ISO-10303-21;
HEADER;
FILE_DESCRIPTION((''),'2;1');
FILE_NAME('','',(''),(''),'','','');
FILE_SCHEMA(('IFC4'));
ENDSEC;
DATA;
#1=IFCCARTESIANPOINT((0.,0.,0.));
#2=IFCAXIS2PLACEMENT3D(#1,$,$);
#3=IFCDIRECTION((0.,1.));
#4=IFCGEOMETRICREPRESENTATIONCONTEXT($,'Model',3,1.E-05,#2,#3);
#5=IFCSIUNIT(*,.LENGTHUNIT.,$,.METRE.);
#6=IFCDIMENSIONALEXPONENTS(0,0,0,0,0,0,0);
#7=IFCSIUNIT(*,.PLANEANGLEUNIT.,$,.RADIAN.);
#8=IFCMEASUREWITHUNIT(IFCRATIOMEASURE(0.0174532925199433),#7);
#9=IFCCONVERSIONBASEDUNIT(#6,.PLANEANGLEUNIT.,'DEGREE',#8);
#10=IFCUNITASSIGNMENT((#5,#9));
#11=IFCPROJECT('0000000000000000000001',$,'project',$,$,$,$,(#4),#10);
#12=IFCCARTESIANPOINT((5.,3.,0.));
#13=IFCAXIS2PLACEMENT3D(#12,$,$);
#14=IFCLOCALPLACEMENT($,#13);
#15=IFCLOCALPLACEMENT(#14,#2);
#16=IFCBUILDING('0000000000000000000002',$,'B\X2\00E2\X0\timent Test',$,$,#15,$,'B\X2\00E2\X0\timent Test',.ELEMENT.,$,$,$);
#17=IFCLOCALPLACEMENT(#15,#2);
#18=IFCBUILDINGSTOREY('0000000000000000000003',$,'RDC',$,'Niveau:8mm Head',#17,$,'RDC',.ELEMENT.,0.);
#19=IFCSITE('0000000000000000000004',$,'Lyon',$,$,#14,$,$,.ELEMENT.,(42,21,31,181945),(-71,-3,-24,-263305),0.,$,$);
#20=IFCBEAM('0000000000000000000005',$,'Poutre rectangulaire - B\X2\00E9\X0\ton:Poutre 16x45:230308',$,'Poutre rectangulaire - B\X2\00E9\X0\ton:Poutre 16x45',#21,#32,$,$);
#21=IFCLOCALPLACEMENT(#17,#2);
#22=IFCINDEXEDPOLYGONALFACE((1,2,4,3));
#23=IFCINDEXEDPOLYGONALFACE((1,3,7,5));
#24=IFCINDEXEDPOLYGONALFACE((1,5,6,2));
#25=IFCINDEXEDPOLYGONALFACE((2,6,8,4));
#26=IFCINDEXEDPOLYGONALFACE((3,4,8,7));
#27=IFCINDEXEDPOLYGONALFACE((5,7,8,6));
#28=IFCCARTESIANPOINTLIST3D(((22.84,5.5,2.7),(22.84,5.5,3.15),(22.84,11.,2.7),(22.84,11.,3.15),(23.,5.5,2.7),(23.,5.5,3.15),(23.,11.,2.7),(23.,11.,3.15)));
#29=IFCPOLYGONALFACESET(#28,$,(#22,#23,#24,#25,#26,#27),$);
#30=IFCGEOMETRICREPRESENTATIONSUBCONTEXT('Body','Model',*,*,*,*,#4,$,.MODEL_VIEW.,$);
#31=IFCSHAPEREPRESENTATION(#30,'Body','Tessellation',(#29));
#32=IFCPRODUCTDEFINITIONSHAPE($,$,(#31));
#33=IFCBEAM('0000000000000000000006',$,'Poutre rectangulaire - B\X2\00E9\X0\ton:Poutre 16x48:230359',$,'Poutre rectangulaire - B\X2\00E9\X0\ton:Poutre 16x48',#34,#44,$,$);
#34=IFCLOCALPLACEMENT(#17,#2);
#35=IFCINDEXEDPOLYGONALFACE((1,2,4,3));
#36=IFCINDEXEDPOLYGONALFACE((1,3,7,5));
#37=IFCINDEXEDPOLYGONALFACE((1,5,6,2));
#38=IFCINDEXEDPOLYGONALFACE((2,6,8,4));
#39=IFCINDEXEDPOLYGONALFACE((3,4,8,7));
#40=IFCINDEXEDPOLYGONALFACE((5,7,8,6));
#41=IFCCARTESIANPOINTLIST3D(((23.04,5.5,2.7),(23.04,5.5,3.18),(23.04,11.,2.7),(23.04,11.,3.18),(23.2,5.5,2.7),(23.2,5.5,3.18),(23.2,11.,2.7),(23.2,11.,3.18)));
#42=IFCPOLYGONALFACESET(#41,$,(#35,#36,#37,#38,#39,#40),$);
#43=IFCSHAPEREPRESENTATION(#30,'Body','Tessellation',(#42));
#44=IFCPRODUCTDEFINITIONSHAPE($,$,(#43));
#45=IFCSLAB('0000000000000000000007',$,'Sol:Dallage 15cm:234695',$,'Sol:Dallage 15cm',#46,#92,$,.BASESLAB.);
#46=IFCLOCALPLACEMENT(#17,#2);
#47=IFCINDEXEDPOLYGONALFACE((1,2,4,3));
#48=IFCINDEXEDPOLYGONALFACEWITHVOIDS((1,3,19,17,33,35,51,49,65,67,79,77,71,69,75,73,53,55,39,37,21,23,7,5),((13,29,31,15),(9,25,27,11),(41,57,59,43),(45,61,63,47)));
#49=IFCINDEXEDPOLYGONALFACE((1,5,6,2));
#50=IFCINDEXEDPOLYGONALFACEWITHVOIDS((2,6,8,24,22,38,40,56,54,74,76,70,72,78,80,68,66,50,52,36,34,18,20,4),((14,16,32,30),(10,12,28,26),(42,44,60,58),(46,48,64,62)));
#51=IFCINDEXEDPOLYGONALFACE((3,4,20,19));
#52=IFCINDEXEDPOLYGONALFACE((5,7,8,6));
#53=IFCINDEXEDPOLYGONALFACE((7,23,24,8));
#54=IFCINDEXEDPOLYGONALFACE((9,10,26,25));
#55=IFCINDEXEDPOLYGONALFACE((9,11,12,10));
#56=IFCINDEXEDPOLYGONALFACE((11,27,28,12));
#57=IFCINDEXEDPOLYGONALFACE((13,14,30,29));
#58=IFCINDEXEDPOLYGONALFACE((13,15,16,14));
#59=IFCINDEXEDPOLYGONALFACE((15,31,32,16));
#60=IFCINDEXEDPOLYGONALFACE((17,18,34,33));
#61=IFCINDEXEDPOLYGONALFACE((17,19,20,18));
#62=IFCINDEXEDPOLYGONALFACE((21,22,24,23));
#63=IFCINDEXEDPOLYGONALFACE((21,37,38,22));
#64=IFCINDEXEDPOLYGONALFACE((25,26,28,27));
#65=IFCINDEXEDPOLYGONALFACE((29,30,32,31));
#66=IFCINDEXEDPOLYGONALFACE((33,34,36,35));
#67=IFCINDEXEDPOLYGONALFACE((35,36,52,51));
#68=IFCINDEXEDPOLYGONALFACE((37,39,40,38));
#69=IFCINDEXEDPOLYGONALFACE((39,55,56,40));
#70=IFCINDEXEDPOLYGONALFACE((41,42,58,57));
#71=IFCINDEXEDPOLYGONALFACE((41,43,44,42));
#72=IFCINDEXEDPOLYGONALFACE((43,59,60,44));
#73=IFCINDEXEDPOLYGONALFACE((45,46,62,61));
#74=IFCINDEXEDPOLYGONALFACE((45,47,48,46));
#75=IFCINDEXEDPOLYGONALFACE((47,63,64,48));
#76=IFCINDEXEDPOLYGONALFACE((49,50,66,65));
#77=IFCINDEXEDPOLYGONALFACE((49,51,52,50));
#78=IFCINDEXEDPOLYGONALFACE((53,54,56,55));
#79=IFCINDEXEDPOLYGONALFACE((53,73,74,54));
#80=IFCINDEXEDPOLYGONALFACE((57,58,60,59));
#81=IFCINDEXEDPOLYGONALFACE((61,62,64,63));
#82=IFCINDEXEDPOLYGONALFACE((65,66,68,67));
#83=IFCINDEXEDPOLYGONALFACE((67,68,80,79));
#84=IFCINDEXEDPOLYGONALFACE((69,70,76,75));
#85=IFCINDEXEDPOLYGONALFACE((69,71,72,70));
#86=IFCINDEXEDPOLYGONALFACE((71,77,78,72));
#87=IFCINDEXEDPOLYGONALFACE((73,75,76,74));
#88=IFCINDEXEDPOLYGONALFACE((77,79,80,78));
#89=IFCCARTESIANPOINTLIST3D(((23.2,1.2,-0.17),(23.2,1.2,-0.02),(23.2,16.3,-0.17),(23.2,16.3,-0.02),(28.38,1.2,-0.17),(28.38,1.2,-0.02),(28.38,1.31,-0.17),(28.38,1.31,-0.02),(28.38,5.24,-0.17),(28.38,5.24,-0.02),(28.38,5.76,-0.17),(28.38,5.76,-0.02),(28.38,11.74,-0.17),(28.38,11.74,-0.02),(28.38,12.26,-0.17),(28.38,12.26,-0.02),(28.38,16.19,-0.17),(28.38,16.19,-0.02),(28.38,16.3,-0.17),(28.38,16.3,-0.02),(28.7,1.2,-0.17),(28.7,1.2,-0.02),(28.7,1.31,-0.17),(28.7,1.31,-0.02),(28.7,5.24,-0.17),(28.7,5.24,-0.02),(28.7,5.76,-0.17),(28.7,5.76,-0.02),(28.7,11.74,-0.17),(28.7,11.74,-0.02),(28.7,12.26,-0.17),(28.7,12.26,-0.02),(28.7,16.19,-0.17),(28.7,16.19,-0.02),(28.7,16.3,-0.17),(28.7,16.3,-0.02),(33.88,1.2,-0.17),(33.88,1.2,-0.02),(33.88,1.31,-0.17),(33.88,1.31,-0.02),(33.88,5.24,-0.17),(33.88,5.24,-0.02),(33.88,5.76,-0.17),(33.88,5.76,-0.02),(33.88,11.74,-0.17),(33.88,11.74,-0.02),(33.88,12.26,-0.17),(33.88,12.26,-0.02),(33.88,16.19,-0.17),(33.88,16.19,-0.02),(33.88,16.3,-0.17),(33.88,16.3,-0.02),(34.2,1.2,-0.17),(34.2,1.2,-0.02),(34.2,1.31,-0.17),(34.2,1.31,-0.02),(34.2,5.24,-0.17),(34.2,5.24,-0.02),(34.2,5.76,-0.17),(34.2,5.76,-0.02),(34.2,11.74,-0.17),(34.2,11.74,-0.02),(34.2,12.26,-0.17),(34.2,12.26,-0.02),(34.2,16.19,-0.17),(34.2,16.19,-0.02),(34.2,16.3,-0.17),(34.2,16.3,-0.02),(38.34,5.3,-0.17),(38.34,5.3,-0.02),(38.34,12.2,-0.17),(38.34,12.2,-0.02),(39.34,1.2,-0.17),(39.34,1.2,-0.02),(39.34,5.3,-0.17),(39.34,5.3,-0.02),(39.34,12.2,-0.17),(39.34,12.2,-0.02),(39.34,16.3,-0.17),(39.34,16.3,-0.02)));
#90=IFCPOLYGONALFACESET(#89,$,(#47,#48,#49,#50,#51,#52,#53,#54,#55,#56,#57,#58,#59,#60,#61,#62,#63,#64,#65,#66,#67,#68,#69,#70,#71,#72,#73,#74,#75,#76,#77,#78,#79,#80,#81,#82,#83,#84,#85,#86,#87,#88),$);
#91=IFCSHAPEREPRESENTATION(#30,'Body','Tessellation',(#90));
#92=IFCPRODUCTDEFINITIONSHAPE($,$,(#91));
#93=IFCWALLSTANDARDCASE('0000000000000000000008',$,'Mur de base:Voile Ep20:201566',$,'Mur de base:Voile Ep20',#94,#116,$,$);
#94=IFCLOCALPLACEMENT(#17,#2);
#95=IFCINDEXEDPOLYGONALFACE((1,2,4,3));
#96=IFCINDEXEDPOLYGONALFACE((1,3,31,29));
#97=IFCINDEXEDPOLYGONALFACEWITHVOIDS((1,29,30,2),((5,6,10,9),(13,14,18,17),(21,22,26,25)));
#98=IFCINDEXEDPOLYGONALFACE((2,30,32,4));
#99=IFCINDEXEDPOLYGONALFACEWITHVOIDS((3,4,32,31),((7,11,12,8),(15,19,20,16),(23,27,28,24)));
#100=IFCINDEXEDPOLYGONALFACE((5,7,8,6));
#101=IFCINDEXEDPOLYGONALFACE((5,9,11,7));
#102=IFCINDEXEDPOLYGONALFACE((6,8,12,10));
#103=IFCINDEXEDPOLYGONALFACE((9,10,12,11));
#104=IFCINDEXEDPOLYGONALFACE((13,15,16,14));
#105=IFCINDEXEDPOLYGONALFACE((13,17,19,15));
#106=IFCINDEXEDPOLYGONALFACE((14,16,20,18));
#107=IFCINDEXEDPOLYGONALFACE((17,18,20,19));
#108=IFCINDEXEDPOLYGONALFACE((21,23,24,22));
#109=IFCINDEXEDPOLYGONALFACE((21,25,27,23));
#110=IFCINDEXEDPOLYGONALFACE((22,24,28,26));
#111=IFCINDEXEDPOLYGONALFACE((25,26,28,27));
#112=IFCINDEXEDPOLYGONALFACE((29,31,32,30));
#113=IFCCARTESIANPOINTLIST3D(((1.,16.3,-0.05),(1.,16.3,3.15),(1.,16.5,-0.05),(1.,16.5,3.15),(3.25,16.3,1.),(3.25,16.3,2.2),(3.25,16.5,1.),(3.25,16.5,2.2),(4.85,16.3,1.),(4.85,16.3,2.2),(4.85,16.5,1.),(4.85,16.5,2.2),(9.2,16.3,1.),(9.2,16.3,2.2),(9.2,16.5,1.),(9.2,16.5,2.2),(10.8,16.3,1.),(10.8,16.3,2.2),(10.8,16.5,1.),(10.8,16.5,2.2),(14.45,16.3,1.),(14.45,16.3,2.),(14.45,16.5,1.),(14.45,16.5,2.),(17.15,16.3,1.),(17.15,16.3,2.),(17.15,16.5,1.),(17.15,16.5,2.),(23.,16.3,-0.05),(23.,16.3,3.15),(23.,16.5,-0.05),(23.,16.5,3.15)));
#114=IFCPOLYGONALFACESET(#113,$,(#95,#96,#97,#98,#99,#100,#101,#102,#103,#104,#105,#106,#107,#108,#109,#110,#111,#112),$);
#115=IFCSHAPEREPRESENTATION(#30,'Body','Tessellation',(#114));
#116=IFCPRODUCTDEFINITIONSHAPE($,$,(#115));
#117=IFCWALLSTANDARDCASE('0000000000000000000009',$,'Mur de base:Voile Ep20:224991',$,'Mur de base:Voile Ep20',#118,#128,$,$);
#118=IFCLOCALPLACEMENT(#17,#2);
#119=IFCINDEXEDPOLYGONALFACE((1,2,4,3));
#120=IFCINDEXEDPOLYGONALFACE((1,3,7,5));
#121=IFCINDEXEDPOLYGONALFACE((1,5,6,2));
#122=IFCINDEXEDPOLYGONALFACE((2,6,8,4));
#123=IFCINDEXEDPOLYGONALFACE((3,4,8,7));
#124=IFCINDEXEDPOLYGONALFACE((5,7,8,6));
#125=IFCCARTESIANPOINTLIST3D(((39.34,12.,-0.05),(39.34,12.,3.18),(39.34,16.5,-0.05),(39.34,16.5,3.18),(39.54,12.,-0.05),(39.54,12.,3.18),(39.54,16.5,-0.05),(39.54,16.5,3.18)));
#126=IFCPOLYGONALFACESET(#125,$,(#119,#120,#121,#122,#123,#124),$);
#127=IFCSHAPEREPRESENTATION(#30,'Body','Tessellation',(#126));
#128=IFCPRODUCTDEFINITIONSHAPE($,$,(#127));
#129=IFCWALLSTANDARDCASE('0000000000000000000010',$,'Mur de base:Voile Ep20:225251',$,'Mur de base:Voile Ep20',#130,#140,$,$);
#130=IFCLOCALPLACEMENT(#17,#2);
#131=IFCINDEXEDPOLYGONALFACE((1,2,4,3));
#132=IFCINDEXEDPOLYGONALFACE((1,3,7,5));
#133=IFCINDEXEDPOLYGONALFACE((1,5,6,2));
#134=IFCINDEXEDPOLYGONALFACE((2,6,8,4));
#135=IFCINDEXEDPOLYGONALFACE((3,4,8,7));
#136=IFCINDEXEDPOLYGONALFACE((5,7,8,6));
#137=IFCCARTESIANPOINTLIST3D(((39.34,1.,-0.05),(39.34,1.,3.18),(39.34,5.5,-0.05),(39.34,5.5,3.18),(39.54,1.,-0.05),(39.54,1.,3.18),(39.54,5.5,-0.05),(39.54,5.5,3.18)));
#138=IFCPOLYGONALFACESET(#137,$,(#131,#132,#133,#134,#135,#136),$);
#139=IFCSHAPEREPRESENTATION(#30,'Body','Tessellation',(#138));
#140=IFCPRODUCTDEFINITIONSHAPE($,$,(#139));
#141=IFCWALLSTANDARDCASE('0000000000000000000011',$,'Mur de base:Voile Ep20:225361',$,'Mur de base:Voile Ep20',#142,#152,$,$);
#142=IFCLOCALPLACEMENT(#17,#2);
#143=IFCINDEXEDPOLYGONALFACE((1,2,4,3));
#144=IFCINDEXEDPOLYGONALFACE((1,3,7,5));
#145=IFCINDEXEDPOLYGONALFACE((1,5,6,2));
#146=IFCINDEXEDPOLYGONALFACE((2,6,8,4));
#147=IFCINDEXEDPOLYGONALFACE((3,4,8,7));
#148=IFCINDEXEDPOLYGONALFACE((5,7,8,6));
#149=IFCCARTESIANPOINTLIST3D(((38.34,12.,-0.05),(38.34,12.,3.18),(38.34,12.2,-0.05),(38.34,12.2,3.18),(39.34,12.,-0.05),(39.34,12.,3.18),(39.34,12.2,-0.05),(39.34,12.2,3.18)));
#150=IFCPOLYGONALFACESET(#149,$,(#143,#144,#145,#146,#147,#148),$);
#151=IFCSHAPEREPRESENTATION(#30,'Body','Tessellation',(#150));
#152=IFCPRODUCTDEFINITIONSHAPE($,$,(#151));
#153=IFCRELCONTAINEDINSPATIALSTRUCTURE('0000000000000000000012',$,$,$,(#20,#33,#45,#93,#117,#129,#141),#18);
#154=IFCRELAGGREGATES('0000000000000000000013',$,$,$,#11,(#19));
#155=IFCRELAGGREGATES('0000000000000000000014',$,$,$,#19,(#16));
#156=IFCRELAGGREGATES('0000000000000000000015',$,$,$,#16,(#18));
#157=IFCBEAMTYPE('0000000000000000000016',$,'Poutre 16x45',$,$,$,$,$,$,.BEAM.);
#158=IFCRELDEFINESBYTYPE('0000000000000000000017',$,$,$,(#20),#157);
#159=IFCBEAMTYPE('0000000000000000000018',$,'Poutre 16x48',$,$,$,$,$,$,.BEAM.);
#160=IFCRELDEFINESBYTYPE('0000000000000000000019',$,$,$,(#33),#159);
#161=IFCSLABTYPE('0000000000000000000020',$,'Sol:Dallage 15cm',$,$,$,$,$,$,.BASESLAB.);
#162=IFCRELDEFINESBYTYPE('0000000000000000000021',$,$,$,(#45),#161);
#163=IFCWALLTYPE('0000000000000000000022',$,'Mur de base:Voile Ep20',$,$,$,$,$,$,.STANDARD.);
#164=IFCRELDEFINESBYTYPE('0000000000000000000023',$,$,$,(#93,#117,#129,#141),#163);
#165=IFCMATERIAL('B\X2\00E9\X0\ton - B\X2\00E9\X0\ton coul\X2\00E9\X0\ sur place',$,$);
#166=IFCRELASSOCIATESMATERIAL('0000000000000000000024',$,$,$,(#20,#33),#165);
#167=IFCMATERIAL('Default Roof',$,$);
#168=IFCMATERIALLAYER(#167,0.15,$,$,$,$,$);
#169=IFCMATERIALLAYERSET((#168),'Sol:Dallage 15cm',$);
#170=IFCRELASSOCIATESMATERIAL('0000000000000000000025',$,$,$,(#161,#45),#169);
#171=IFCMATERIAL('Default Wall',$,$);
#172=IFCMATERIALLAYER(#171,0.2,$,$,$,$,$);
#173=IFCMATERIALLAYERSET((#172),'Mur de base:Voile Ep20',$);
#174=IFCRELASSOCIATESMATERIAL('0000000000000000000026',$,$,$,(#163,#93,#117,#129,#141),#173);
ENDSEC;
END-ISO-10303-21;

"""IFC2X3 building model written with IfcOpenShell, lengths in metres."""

from ifc_helpers import new_model, entity, si_unit, converted_unit, direction, frame, frame_2d, origin, origin_2d_with_axis, place, context, subcontext, project, spatial, polyline, rectangle, outline, extrude, material, layer, layer_set, layer_usage, type_object, element, save


model = new_model("IFC2X3")

# Units and contexts
model_context = context("Model", 3, precision=1e-05, world=origin(), true_north=direction((0.0, 1.0)))
body_context = subcontext(model_context, "Body", "Model", "MODEL_VIEW")
ifc_project = project(units=[si_unit("LENGTHUNIT", "METRE"), converted_unit("PLANEANGLEUNIT", "DEGREE", entity("IfcRatioMeasure", 0.0174532925199433), si_unit("PLANEANGLEUNIT", "RADIAN"), dimensions=[0, 0, 0, 0, 0, 0, 0])], contexts=[model_context])

# Site, building, storey
site_placement = place(None, frame((5.0, 3.0, 0.0)))
site = spatial("IfcSite", under=ifc_project, at=site_placement, Name="Lyon", CompositionType="ELEMENT", RefLatitude=(42, 21, 31, 181945), RefLongitude=(-71, -3, -24, -263305), RefElevation=0.0)
building_placement = place(site_placement, origin())
building = spatial("IfcBuilding", under=site, at=building_placement, Name="Bâtiment Test", LongName="Bâtiment Test", CompositionType="ELEMENT")
storey_placement = place(building_placement, origin())
storey = spatial("IfcBuildingStorey", under=building, at=storey_placement, Name="RDC", ObjectType="Niveau:8mm Head", LongName="RDC", CompositionType="ELEMENT", Elevation=0.0)

# Beams
ifc_material_1 = material(Name="Béton - Béton coulé sur place")
beam_type_1 = type_object("IfcBeamType", Name="Poutre 16x45", PredefinedType="BEAM")
beam_1_placement = place(storey_placement, frame((22.92, 5.5, 3.15), z_axis=(0.0, 0.0, 1.0), x_axis=(0.0, 1.0, 0.0)))
element("IfcBeam", 1, at=beam_1_placement, inside=storey, type_object=beam_type_1, material=ifc_material_1, Name="Poutre rectangulaire - Béton:Poutre 16x45:230308", ObjectType="Poutre rectangulaire - Béton:Poutre 16x45", context=body_context, shape_type="SweptSolid", body=[
    extrude(rectangle(XDim=0.45, YDim=0.16, at=frame_2d((0.0, 0.0), x_axis=(1.0, 0.0))), frame((0.0, 0.0, -0.225), z_axis=(1.0, 0.0, 0.0), x_axis=(0.0, 0.0, -1.0)), (0.0, 0.0, 1.0), 5.5),
])
beam_type_2 = type_object("IfcBeamType", Name="Poutre 16x48", PredefinedType="BEAM")
beam_2_placement = place(storey_placement, frame((23.12, 11.0, 3.18), z_axis=(0.0, 0.0, 1.0), x_axis=(0.0, -1.0, 0.0)))
element("IfcBeam", 2, at=beam_2_placement, inside=storey, type_object=beam_type_2, material=ifc_material_1, Name="Poutre rectangulaire - Béton:Poutre 16x48:230359", ObjectType="Poutre rectangulaire - Béton:Poutre 16x48", context=body_context, shape_type="SweptSolid", body=[
    extrude(rectangle(XDim=0.48, YDim=0.16, at=frame_2d((0.0, 0.0), x_axis=(1.0, 0.0))), frame((0.0, 0.0, -0.24), z_axis=(1.0, 0.0, 0.0), x_axis=(0.0, 0.0, -1.0)), (0.0, 0.0, 1.0), 5.5),
])

# Slab, openings
ifc_material_2 = material(Name="Default Roof")
ifc_layer_1 = layer(ifc_material_2, 0.15)
ifc_layer_set_1 = layer_set([ifc_layer_1], Name="Sol:Dallage 15cm")
ifc_layer_usage_1 = layer_usage(ifc_layer_set_1, "AXIS3", "POSITIVE", 0.0)
slab_type = type_object("IfcSlabType", Name="Sol:Dallage 15cm", PredefinedType="BASESLAB", material=ifc_layer_set_1)
slab_placement = place(storey_placement, frame((23.2, 1.2, -0.17)))
slab = element("IfcSlab", 3, at=slab_placement, inside=storey, type_object=slab_type, material=ifc_layer_usage_1, Name="Sol:Dallage 15cm:234695", ObjectType="Sol:Dallage 15cm", PredefinedType="BASESLAB", context=body_context, shape_type="SweptSolid", body=[
    extrude(outline(polyline([(8.07, 7.55), (2.89, 7.55), (2.89, 7.44), (2.57, 7.44), (2.57, 7.55), (-2.61, 7.55), (-2.61, 7.44), (-2.93, 7.44), (-2.93, 7.55), (-8.07, 7.55), (-8.07, 3.45), (-7.07, 3.45), (-7.07, -3.45), (-8.07, -3.45), (-8.07, -7.55), (-2.93, -7.55), (-2.93, -7.44), (-2.61, -7.44), (-2.61, -7.55), (2.57, -7.55), (2.57, -7.44), (2.89, -7.44), (2.89, -7.55), (8.07, -7.55), (8.07, 7.55)])), frame((8.07, 7.55, 0.15), z_axis=(0.0, 0.0, -1.0), x_axis=(-1.0, 0.0, 0.0)), (0.0, 0.0, 1.0), 0.15),
])
opening_1_placement = place(slab_placement, frame((5.34, 10.8, 0.15)))
element("IfcOpeningElement", 4, at=opening_1_placement, cuts=slab, ObjectType="Opening", context=body_context, shape_type="SweptSolid", body=[
    extrude(rectangle(XDim=0.52, YDim=0.32, at=origin_2d_with_axis()), frame((0.0, 0.0, 0.0), z_axis=(0.0, 0.0, -1.0), x_axis=(0.0, -1.0, 0.0)), (0.0, 0.0, 1.0), 0.15),
])
opening_2_placement = place(slab_placement, frame((10.84, 10.8, 0.15)))
element("IfcOpeningElement", 5, at=opening_2_placement, cuts=slab, ObjectType="Opening", context=body_context, shape_type="SweptSolid", body=[
    extrude(rectangle(XDim=0.52, YDim=0.32, at=origin_2d_with_axis()), frame((0.0, 0.0, 0.0), z_axis=(0.0, 0.0, -1.0), x_axis=(0.0, -1.0, 0.0)), (0.0, 0.0, 1.0), 0.15),
])
opening_3_placement = place(slab_placement, frame((5.34, 4.3, 0.15)))
element("IfcOpeningElement", 6, at=opening_3_placement, cuts=slab, ObjectType="Opening", context=body_context, shape_type="SweptSolid", body=[
    extrude(rectangle(XDim=0.52, YDim=0.32, at=origin_2d_with_axis()), frame((0.0, 0.0, 0.0), z_axis=(0.0, 0.0, -1.0), x_axis=(0.0, -1.0, 0.0)), (0.0, 0.0, 1.0), 0.15),
])
opening_4_placement = place(slab_placement, frame((10.84, 4.3, 0.15)))
element("IfcOpeningElement", 7, at=opening_4_placement, cuts=slab, ObjectType="Opening", context=body_context, shape_type="SweptSolid", body=[
    extrude(rectangle(XDim=0.52, YDim=0.32, at=origin_2d_with_axis()), frame((0.0, 0.0, 0.0), z_axis=(0.0, 0.0, -1.0), x_axis=(0.0, -1.0, 0.0)), (0.0, 0.0, 1.0), 0.15),
])

# Wall, openings
ifc_material_3 = material(Name="Default Wall")
ifc_layer_2 = layer(ifc_material_3, 0.2)
ifc_layer_set_2 = layer_set([ifc_layer_2], Name="Mur de base:Voile Ep20")
ifc_layer_usage_2 = layer_usage(ifc_layer_set_2, "AXIS2", "POSITIVE", -0.1)
wall_type_1 = type_object("IfcWallType", Name="Mur de base:Voile Ep20", PredefinedType="STANDARD", material=ifc_layer_set_2)
wall_1_placement = place(storey_placement, frame((23.0, 16.4, -0.05), z_axis=(0.0, 0.0, 1.0), x_axis=(-1.0, 0.0, 0.0)))
wall_1 = element("IfcWallStandardCase", 8, at=wall_1_placement, inside=storey, type_object=wall_type_1, material=ifc_layer_usage_2, Name="Mur de base:Voile Ep20:201566", ObjectType="Mur de base:Voile Ep20", context=body_context, shape_type="SweptSolid", body=[
    extrude(rectangle(XDim=22.0, YDim=0.2, at=frame_2d((11.0, 0.0), x_axis=(-1.0, 0.0))), origin(), (0.0, 0.0, 1.0), 3.2),
])
opening_5_placement = place(wall_1_placement, origin())
element("IfcOpeningElement", 9, at=opening_5_placement, cuts=wall_1, ObjectType="Opening", context=body_context, shape_type="SweptSolid", body=[
    extrude(rectangle(XDim=1.0, YDim=2.7, at=frame_2d((0.0, 0.0), x_axis=(1.0, 0.0))), frame((7.2, -0.1, 1.55), z_axis=(0.0, 1.0, 0.0), x_axis=(0.0, 0.0, -1.0)), (0.0, 0.0, 1.0), 0.2),
])
opening_6_placement = place(wall_1_placement, origin())
element("IfcOpeningElement", 10, at=opening_6_placement, cuts=wall_1, ObjectType="Opening", context=body_context, shape_type="SweptSolid", body=[
    extrude(rectangle(XDim=1.2, YDim=1.6, at=frame_2d((0.0, 0.0), x_axis=(1.0, 0.0))), frame((13.0, -0.1, 1.65), z_axis=(0.0, 1.0, 0.0), x_axis=(0.0, 0.0, -1.0)), (0.0, 0.0, 1.0), 0.2),
])
opening_7_placement = place(wall_1_placement, origin())
element("IfcOpeningElement", 11, at=opening_7_placement, cuts=wall_1, ObjectType="Opening", context=body_context, shape_type="SweptSolid", body=[
    extrude(rectangle(XDim=1.2, YDim=1.6, at=frame_2d((0.0, 0.0), x_axis=(1.0, 0.0))), frame((18.95, -0.1, 1.65), z_axis=(0.0, 1.0, 0.0), x_axis=(0.0, 0.0, -1.0)), (0.0, 0.0, 1.0), 0.2),
])

# Walls
ifc_layer_usage_3 = layer_usage(ifc_layer_set_2, "AXIS2", "NEGATIVE", 0.1)
wall_2_placement = place(storey_placement, frame((39.44, 16.5, -0.05), z_axis=(0.0, 0.0, 1.0), x_axis=(0.0, -1.0, 0.0)))
element("IfcWallStandardCase", 12, at=wall_2_placement, inside=storey, type_object=wall_type_1, material=ifc_layer_usage_3, Name="Mur de base:Voile Ep20:224991", ObjectType="Mur de base:Voile Ep20", context=body_context, shape_type="SweptSolid", body=[
    extrude(rectangle(XDim=4.5, YDim=0.2, at=frame_2d((2.25, 0.0), x_axis=(-1.0, 0.0))), origin(), (0.0, 0.0, 1.0), 3.23),
])
ifc_layer_usage_4 = layer_usage(ifc_layer_set_2, "AXIS2", "NEGATIVE", 0.1)
wall_3_placement = place(storey_placement, frame((39.44, 5.5, -0.05), z_axis=(0.0, 0.0, 1.0), x_axis=(0.0, -1.0, 0.0)))
element("IfcWallStandardCase", 13, at=wall_3_placement, inside=storey, type_object=wall_type_1, material=ifc_layer_usage_4, Name="Mur de base:Voile Ep20:225251", ObjectType="Mur de base:Voile Ep20", context=body_context, shape_type="SweptSolid", body=[
    extrude(rectangle(XDim=4.5, YDim=0.2, at=frame_2d((2.25, 0.0), x_axis=(-1.0, 0.0))), origin(), (0.0, 0.0, 1.0), 3.23),
])
ifc_layer_usage_5 = layer_usage(ifc_layer_set_2, "AXIS2", "NEGATIVE", 0.1)
wall_4_placement = place(storey_placement, frame((39.34, 12.1, -0.05), z_axis=(0.0, 0.0, 1.0), x_axis=(-1.0, 0.0, 0.0)))
element("IfcWallStandardCase", 14, at=wall_4_placement, inside=storey, type_object=wall_type_1, material=ifc_layer_usage_5, Name="Mur de base:Voile Ep20:225361", ObjectType="Mur de base:Voile Ep20", context=body_context, shape_type="SweptSolid", body=[
    extrude(rectangle(XDim=1.0, YDim=0.2, at=frame_2d((0.5, 0.0), x_axis=(-1.0, 0.0))), origin(), (0.0, 0.0, 1.0), 3.23),
])

save(model, "model.ifc")
